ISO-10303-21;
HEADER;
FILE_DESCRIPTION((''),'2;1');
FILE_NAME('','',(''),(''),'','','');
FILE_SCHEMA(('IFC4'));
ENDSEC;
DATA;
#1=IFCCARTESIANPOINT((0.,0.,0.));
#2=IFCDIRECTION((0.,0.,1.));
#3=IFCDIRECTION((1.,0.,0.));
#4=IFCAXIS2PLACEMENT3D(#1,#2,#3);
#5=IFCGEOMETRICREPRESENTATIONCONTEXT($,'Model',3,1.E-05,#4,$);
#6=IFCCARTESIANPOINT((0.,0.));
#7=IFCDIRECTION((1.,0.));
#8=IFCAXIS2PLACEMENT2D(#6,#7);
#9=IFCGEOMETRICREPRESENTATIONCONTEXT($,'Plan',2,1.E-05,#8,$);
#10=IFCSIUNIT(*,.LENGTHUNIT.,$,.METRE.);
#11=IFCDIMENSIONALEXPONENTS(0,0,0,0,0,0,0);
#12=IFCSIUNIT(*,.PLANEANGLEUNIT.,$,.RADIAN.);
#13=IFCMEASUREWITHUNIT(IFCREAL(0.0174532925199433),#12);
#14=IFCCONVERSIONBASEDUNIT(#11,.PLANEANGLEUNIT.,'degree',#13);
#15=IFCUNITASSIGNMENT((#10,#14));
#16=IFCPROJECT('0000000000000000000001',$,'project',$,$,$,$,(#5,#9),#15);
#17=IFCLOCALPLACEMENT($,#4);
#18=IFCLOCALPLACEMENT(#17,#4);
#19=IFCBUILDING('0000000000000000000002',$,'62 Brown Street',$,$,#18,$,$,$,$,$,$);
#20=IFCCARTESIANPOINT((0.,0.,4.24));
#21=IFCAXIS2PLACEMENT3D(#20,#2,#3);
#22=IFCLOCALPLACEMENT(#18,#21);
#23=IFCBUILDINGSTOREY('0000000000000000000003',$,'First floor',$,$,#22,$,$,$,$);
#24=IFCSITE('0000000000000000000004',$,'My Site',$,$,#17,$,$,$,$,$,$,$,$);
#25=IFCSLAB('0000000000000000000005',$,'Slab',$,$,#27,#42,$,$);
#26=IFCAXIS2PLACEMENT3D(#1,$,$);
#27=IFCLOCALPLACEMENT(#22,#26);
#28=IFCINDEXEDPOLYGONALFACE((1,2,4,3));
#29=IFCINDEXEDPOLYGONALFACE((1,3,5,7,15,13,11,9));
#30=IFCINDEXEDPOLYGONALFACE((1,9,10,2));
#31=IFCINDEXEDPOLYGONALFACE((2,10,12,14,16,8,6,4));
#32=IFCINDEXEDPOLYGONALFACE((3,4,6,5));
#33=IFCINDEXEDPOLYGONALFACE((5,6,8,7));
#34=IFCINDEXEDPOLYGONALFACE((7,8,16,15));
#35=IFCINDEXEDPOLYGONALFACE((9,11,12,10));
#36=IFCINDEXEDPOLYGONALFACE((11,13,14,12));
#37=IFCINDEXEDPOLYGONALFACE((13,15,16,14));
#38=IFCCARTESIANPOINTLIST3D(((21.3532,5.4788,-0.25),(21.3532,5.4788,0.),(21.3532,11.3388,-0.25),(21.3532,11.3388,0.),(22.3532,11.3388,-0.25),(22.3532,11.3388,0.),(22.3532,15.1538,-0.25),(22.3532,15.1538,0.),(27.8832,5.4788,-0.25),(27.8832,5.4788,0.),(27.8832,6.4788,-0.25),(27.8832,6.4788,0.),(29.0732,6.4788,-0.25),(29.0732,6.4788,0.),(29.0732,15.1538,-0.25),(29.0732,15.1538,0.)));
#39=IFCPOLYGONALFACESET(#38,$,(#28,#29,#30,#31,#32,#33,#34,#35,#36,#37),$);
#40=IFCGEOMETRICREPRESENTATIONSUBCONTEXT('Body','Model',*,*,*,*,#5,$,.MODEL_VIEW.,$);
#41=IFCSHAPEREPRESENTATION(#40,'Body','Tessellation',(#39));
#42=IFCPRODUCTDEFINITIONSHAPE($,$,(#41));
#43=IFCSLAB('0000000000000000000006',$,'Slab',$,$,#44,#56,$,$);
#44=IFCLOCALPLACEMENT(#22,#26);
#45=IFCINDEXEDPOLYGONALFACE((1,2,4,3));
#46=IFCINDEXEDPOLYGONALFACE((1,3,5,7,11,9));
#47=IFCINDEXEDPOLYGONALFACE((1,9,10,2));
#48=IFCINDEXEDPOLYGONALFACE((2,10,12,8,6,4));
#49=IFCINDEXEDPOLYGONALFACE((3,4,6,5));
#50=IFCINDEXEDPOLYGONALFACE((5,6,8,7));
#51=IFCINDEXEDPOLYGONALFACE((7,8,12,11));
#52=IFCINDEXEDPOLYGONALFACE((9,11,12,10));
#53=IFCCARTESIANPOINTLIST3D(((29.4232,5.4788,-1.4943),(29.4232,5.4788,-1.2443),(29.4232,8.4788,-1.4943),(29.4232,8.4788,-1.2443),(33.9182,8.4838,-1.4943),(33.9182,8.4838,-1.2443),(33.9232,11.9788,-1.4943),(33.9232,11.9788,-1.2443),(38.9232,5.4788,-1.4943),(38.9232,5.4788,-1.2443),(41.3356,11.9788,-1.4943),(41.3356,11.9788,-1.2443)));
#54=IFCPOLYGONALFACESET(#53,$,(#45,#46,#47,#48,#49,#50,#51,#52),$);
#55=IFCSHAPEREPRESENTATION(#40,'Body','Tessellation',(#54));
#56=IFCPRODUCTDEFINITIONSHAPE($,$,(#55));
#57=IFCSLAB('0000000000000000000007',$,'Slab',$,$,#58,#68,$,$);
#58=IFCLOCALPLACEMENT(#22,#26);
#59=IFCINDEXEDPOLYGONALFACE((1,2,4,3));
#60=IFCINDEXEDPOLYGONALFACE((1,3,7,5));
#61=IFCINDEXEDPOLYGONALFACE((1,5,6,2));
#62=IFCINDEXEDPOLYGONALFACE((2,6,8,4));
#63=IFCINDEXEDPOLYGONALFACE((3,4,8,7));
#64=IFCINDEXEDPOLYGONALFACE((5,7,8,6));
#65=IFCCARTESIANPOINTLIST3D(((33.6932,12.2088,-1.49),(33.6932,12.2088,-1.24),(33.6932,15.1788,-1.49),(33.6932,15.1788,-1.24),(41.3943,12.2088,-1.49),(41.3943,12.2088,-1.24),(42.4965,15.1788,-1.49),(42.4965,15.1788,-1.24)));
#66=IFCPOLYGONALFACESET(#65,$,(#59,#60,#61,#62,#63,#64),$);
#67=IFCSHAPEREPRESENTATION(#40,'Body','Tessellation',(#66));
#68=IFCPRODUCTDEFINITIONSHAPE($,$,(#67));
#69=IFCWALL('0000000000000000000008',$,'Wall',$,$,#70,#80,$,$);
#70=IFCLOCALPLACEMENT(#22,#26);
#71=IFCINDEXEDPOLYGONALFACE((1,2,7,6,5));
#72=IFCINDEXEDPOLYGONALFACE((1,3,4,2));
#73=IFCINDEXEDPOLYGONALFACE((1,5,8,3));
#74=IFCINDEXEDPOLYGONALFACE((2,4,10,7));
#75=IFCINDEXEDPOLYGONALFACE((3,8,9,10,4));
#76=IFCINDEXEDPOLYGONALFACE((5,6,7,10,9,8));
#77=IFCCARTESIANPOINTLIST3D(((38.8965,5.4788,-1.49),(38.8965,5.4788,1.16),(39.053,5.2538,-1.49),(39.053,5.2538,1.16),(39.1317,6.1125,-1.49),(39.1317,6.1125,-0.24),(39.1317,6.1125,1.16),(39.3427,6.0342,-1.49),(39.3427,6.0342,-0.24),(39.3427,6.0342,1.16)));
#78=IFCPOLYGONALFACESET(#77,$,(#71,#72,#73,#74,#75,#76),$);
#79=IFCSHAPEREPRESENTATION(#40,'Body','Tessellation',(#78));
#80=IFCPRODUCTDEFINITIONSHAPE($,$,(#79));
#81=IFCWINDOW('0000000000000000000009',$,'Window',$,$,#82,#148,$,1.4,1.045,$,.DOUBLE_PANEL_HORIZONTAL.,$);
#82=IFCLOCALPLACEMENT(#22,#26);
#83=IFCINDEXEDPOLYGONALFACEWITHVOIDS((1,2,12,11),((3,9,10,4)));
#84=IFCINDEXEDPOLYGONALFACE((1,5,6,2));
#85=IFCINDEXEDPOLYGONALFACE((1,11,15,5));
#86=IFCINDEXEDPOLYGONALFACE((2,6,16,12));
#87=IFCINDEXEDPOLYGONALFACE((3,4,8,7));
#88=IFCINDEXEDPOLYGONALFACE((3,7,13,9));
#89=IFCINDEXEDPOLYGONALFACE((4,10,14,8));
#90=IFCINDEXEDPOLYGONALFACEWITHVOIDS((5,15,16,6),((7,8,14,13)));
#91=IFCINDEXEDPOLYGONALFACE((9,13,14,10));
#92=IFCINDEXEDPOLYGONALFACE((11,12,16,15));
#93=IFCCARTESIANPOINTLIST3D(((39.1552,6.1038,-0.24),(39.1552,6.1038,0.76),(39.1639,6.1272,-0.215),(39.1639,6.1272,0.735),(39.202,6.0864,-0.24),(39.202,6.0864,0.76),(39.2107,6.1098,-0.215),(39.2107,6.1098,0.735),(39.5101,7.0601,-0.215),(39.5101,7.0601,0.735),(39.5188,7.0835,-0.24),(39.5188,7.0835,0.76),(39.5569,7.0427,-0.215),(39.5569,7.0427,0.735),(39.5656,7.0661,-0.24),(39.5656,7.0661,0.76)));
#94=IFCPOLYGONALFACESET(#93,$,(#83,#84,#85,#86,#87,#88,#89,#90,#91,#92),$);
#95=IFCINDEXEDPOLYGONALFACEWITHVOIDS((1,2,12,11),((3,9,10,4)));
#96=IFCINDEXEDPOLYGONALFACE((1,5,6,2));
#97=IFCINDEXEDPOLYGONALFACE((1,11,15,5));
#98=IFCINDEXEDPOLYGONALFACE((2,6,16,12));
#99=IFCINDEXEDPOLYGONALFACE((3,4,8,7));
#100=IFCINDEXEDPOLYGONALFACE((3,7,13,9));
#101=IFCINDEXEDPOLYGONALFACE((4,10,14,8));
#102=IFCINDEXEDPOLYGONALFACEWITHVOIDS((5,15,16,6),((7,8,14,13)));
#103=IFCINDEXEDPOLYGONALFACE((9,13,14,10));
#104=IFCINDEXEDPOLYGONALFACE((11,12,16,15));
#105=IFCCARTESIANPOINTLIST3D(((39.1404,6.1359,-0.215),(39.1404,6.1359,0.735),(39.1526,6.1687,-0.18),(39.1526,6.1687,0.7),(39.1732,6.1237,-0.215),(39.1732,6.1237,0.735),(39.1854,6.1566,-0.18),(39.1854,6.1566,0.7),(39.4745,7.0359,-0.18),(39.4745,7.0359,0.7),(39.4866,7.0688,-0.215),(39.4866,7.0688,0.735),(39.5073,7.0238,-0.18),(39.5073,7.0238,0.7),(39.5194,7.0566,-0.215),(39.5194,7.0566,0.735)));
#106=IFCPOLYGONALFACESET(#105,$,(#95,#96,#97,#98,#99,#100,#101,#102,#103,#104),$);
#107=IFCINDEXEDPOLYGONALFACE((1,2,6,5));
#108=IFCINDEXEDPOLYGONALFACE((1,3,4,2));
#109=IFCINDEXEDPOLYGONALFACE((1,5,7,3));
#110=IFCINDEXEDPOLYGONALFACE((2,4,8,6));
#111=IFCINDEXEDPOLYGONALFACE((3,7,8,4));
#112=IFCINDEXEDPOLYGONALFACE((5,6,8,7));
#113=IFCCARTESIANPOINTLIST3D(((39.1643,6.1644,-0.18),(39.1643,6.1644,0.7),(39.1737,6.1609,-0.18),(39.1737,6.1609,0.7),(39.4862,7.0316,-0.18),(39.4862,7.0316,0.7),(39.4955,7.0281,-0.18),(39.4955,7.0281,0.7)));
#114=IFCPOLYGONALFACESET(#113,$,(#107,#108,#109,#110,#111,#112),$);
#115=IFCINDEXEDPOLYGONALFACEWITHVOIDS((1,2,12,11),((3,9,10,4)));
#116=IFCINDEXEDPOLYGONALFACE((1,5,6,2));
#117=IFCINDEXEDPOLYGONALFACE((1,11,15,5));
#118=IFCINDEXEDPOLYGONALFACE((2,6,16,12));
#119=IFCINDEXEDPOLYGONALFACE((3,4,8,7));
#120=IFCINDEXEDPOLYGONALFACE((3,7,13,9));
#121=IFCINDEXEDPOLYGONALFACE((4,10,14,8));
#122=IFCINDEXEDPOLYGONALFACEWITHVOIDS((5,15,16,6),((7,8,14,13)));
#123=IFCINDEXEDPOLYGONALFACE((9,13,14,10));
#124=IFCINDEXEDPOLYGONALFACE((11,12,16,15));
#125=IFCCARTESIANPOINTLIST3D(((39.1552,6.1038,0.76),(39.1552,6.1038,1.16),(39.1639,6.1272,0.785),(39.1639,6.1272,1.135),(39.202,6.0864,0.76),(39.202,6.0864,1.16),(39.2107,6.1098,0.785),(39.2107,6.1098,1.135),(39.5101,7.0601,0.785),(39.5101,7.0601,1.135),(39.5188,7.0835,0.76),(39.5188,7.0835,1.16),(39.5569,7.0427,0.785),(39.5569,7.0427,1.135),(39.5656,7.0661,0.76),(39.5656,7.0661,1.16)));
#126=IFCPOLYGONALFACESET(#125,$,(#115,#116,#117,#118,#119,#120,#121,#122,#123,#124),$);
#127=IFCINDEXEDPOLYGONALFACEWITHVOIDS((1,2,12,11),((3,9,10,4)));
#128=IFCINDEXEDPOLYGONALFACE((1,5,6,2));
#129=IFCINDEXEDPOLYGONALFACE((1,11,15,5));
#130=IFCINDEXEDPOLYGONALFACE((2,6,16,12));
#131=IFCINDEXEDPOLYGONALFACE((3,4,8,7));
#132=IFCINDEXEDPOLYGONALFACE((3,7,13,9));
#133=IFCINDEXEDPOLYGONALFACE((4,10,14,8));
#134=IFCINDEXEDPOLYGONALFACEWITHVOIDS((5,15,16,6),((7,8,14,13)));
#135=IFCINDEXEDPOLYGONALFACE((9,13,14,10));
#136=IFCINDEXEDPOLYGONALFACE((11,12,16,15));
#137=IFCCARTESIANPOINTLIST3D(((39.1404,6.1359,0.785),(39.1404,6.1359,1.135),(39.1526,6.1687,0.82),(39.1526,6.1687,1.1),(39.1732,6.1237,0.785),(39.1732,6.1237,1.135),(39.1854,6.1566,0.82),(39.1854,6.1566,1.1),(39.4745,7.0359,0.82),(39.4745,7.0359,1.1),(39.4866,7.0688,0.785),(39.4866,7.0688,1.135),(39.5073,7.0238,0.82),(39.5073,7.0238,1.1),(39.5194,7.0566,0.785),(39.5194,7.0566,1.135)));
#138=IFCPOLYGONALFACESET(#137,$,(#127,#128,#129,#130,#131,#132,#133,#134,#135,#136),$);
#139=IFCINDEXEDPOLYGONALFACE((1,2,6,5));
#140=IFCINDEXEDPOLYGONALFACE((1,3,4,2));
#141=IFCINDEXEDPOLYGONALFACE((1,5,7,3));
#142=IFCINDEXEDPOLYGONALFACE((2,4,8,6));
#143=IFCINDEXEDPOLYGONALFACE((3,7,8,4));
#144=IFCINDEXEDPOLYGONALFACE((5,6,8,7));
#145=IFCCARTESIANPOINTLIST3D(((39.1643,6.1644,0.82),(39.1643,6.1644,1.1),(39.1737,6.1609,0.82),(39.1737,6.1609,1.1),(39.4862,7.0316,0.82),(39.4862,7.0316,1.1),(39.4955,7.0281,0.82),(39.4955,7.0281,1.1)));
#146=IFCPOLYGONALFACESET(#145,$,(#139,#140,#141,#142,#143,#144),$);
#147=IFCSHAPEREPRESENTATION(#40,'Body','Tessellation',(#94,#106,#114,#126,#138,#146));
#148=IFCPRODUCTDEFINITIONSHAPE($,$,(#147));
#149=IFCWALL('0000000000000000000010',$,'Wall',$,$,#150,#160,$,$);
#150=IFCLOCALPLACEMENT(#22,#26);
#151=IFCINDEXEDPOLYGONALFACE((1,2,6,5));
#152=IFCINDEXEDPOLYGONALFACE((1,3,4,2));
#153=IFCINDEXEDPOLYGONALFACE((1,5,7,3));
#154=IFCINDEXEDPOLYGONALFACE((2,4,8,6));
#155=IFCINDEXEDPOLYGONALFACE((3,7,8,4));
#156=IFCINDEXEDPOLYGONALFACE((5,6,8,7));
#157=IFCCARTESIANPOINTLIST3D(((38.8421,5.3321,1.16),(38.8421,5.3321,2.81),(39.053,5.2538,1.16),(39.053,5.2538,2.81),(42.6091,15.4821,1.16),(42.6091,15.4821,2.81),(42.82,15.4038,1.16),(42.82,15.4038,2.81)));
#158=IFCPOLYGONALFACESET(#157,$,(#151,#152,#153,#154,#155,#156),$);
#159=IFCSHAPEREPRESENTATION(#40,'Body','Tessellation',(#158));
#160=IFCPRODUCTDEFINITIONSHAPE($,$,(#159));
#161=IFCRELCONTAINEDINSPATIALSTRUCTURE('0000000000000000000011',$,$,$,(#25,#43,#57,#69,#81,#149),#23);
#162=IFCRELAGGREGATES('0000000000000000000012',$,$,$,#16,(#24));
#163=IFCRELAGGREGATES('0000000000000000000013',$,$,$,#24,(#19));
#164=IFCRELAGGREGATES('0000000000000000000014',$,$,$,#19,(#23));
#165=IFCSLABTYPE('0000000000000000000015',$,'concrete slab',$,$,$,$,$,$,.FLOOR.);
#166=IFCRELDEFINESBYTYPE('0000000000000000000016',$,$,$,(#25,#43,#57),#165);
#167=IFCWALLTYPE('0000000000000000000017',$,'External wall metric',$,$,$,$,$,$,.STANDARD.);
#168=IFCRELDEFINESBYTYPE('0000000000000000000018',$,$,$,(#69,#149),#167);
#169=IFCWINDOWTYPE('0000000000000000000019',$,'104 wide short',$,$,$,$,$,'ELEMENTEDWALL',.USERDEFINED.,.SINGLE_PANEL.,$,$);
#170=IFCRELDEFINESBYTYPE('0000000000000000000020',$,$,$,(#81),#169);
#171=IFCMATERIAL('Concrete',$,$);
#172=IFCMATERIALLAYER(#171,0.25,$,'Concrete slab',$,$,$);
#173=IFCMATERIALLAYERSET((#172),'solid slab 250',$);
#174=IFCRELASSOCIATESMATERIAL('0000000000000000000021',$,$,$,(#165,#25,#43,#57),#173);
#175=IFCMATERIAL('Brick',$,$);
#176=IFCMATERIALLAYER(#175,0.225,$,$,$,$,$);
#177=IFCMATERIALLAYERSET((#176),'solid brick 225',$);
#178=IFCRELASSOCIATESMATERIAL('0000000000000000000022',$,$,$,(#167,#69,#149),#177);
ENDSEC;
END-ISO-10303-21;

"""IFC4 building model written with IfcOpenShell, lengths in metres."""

from ifc_helpers import new_model, entity, si_unit, converted_unit, frame, origin_with_axes, origin_2d_with_axis, place, context, subcontext, project, spatial, line, indexed_curve, outline, extrude, clip, halfspace, shape, source, transform, mapped, material, layer, layer_set, layer_usage, type_object, type_shapes, element, fill, save


model = new_model("IFC4")

# Units and contexts
model_context = context("Model", 3, precision=1e-05, world=origin_with_axes())
plan_context = context("Plan", 2, precision=1e-05, world=origin_2d_with_axis())
body_context_1 = subcontext(model_context, "Body", "Model", "MODEL_VIEW")
body_context_2 = subcontext(plan_context, "Body", "Plan", "PLAN_VIEW")
ifc_project = project(units=[si_unit("LENGTHUNIT", "METRE"), converted_unit("PLANEANGLEUNIT", "degree", entity("IfcReal", 0.0174532925199433), si_unit("PLANEANGLEUNIT", "RADIAN"), dimensions=[0, 0, 0, 0, 0, 0, 0])], contexts=[model_context, plan_context])

# Site, building, storey
site_placement = place(None, origin_with_axes())
site = spatial("IfcSite", under=ifc_project, at=site_placement, Name="My Site")
building_placement = place(site_placement, origin_with_axes())
building = spatial("IfcBuilding", under=site, at=building_placement, Name="62 Brown Street")
storey_placement = place(building_placement, frame((0.0, 0.0, 4.24), z_axis=(0.0, 0.0, 1.0), x_axis=(1.0, 0.0, 0.0)))
storey = spatial("IfcBuildingStorey", under=building, at=storey_placement, Name="First floor")

# Slabs
ifc_material_1 = material(Name="Concrete")
ifc_layer_1 = layer(ifc_material_1, 0.25, Name="Concrete slab")
ifc_layer_set_1 = layer_set([ifc_layer_1], Name="solid slab 250")
ifc_layer_usage_1 = layer_usage(ifc_layer_set_1, "AXIS3", "POSITIVE", 0.0)
slab_type = type_object("IfcSlabType", Name="concrete slab", PredefinedType="FLOOR", material=ifc_layer_set_1)
slab_1_placement = place(storey_placement, frame((21.3532, 5.4788, -0.25), z_axis=(0.0, 0.0, 1.0), x_axis=(1.0, 0.0, 0.0)))
element("IfcSlab", 1, at=slab_1_placement, inside=storey, type_object=slab_type, material=ifc_layer_usage_1, Name="Slab", context=body_context_1, shape_type="SweptSolid", body=[
    extrude(outline(indexed_curve([(0.0, 0.0), (0.0, 5.86), (1.0, 5.86), (1.0, 9.675), (7.72, 9.675), (7.72, 1.0), (6.53, 1.0), (6.53, 0.0)], segments=[line(2, 1), line(1, 8), line(8, 7), line(7, 6), line(6, 5), line(5, 4), line(4, 3), line(3, 2)], self_intersect=False)), None, (0.0, 0.0, 1.0), 0.25),
])
ifc_layer_usage_2 = layer_usage(ifc_layer_set_1, "AXIS3", "POSITIVE", 0.0)
slab_2_placement = place(storey_placement, frame((29.4232, 5.4788, -1.4943), z_axis=(0.0, 0.0, 1.0), x_axis=(1.0, 0.0, 0.0)))
element("IfcSlab", 2, at=slab_2_placement, inside=storey, type_object=slab_type, material=ifc_layer_usage_2, Name="Slab", context=body_context_1, shape_type="SweptSolid", body=[
    extrude(outline(indexed_curve([(0.0, 0.0), (9.5, 0.0), (11.9124, 6.5), (0.0, 3.0), (4.5, 6.5), (4.495, 3.005)], segments=[line(1, 2), line(2, 3), line(3, 5), line(5, 6), line(6, 4), line(4, 1)], self_intersect=False)), None, (0.0, 0.0, 1.0), 0.25),
])
ifc_layer_usage_3 = layer_usage(ifc_layer_set_1, "AXIS3", "POSITIVE", 0.0)
slab_3_placement = place(storey_placement, frame((33.6932, 12.2088, -1.49), z_axis=(0.0, 0.0, 1.0), x_axis=(1.0, 0.0, 0.0)))
element("IfcSlab", 3, at=slab_3_placement, inside=storey, type_object=slab_type, material=ifc_layer_usage_3, Name="Slab", context=body_context_1, shape_type="SweptSolid", body=[
    extrude(outline(indexed_curve([(8.8033, 2.97), (7.7011, 0.0), (0.0, 0.0), (0.0, 2.97)], segments=[line(4, 1), line(1, 2), line(2, 3), line(3, 4)], self_intersect=False)), None, (0.0, 0.0, 1.0), 0.25),
])

# Shared definitions
ifc_material_2 = material(Name="Brick")
ifc_layer_2 = layer(ifc_material_2, 0.225)
ifc_layer_set_2 = layer_set([ifc_layer_2], Name="solid brick 225")
wall_type_1 = type_object("IfcWallType", Name="External wall metric", PredefinedType="STANDARD", material=ifc_layer_set_2)

# Wall, opening, window
ifc_layer_usage_4 = layer_usage(ifc_layer_set_2, "AXIS2", "POSITIVE", 0.0)
wall_1_placement = place(storey_placement, frame((39.024, 5.1755, -1.49), z_axis=(0.0, 0.0, 1.0), x_axis=(0.347944, 0.937515, 0.0)))
wall_1 = element("IfcWall", 4, at=wall_1_placement, inside=storey, type_object=wall_type_1, material=ifc_layer_usage_4, Name="Wall", context=body_context_1, shape_type="Clipping", body=[
    clip(extrude(outline(indexed_curve([(0.0, 0.0), (0.0, 0.225), (0.9159, 0.225), (0.9159, 0.0), (0.0, 0.0)], self_intersect=False)), origin_with_axes(), (0.0, 0.0, 1.0), 2.65), halfspace(frame((0.0835, 0.0, -2.75), z_axis=(-0.596249, 0.414702, 0.0), x_axis=(0.156491, 0.225, 0.0)), False)),
])
shared_shape_1 = source(origin_with_axes(), body_context_1, "Body", "SweptSolid", [
    extrude(outline(indexed_curve([(0.0, 0.0), (1.045, 0.0), (1.045, 1.4), (0.0, 1.4)], segments=[line(1, 2, 3, 4, 1)])), frame((0.0, -0.1, 0.0), z_axis=(0.0, -1.0, 0.0), x_axis=(1.0, 0.0, 0.0)), (0.0, 0.0, -1.0), 0.425),
])
opening_placement = place(wall_1_placement, frame((0.9159, 0.0, 1.25), z_axis=(0.0, 0.0, 1.0), x_axis=(1.0, 0.0, 0.0)))
opening = element("IfcOpeningElement", 5, at=opening_placement, cuts=wall_1, PredefinedType="OPENING", context=body_context_1, shape_type="MappedRepresentation", body=[
    mapped(shared_shape_1, transform((0.0, 0.0, 0.0), x_axis=(1.0, 0.0, 0.0), y_axis=(0.0, 1.0, 0.0), z_axis=(0.0, 0.0, 1.0), scale=1.0)),
])
window_type = type_object("IfcWindowType", Name="104 wide short", ElementType="ELEMENTEDWALL", PartitioningType="SINGLE_PANEL", PredefinedType="USERDEFINED")
shared_shape_2 = source(origin_with_axes(), body_context_1, "Body", "SweptSolid", [
    extrude(outline(indexed_curve([(0.0, 0.0), (1.045, 0.0), (1.045, 1.0), (0.0, 1.0)], segments=[line(1, 2, 3, 4, 1)]), holes=[indexed_curve([(0.025, 0.025), (1.02, 0.025), (1.02, 0.975), (0.025, 0.975)], segments=[line(1, 2, 3, 4, 1)])]), frame((0.0, 0.15, 0.0), z_axis=(0.0, -1.0, 0.0), x_axis=(1.0, 0.0, 0.0)), (0.0, 0.0, -1.0), 0.05),
    extrude(outline(indexed_curve([(0.0, 0.0), (0.995, 0.0), (0.995, 0.95), (0.0, 0.95)], segments=[line(1, 2, 3, 4, 1)]), holes=[indexed_curve([(0.035, 0.035), (0.96, 0.035), (0.96, 0.915), (0.035, 0.915)], segments=[line(1, 2, 3, 4, 1)])]), frame((0.025, 0.19, 0.025), z_axis=(0.0, -1.0, 0.0), x_axis=(1.0, 0.0, 0.0)), (0.0, 0.0, -1.0), 0.035),
    extrude(outline(indexed_curve([(0.035, 0.035), (0.96, 0.035), (0.96, 0.915), (0.035, 0.915)], segments=[line(1, 2, 3, 4, 1)])), frame((0.025, 0.2025, 0.025), z_axis=(0.0, -1.0, 0.0), x_axis=(1.0, 0.0, 0.0)), (0.0, 0.0, -1.0), 0.01),
    extrude(outline(indexed_curve([(0.0, 0.0), (1.045, 0.0), (1.045, 0.4), (0.0, 0.4)], segments=[line(1, 2, 3, 4, 1)]), holes=[indexed_curve([(0.025, 0.025), (1.02, 0.025), (1.02, 0.375), (0.025, 0.375)], segments=[line(1, 2, 3, 4, 1)])]), frame((0.0, 0.15, 1.0), z_axis=(0.0, -1.0, 0.0), x_axis=(1.0, 0.0, 0.0)), (0.0, 0.0, -1.0), 0.05),
    extrude(outline(indexed_curve([(0.0, 0.0), (0.995, 0.0), (0.995, 0.35), (0.0, 0.35)], segments=[line(1, 2, 3, 4, 1)]), holes=[indexed_curve([(0.035, 0.035), (0.96, 0.035), (0.96, 0.315), (0.035, 0.315)], segments=[line(1, 2, 3, 4, 1)])]), frame((0.025, 0.19, 1.025), z_axis=(0.0, -1.0, 0.0), x_axis=(1.0, 0.0, 0.0)), (0.0, 0.0, -1.0), 0.035),
    extrude(outline(indexed_curve([(0.035, 0.035), (0.96, 0.035), (0.96, 0.315), (0.035, 0.315)], segments=[line(1, 2, 3, 4, 1)])), frame((0.025, 0.2025, 1.025), z_axis=(0.0, -1.0, 0.0), x_axis=(1.0, 0.0, 0.0)), (0.0, 0.0, -1.0), 0.01),
])
shared_shape_3 = source(origin_with_axes(), body_context_2, "Body", "Curve2D", [
    entity("IfcIndexedPolyCurve", entity("IfcCartesianPointList2D", [[0.025, 0.15], [1.02, 0.15]])),
    entity("IfcIndexedPolyCurve", entity("IfcCartesianPointList2D", [[0.0, 0.2], [0.025, 0.2], [0.025, 0.15], [0.0, 0.15]]), [entity("IfcLineIndex", [1, 2, 3, 4, 1])]),
    entity("IfcIndexedPolyCurve", entity("IfcCartesianPointList2D", [[1.045, 0.2], [1.02, 0.2], [1.02, 0.15], [1.045, 0.15]]), [entity("IfcLineIndex", [1, 2, 3, 4, 1])]),
    entity("IfcIndexedPolyCurve", entity("IfcCartesianPointList2D", [[0.025, 0.19], [0.06, 0.19], [0.06, 0.225], [0.025, 0.225]]), [entity("IfcLineIndex", [1, 2, 3, 4, 1])]),
    entity("IfcIndexedPolyCurve", entity("IfcCartesianPointList2D", [[1.02, 0.19], [0.985, 0.19], [0.985, 0.225], [1.02, 0.225]]), [entity("IfcLineIndex", [1, 2, 3, 4, 1])]),
    entity("IfcIndexedPolyCurve", entity("IfcCartesianPointList2D", [[0.06, 0.19], [0.985, 0.19]])),
    entity("IfcIndexedPolyCurve", entity("IfcCartesianPointList2D", [[0.06, 0.225], [0.985, 0.225]])),
    entity("IfcIndexedPolyCurve", entity("IfcCartesianPointList2D", [[0.06, 0.2075], [0.985, 0.2075]])),
])
type_shapes(window_type, [shared_shape_2, shared_shape_3])
window_1_placement = place(opening_placement, frame((0.0, 0.0, 0.0), z_axis=(0.0, 0.0, 1.0), x_axis=(1.0, 0.0, 0.0)))
window_1 = element("IfcWindow", 6, at=window_1_placement, inside=storey, type_object=window_type, Name="Window", OverallHeight=1.4, OverallWidth=1.045, PartitioningType="DOUBLE_PANEL_HORIZONTAL", shapes=[
    shape(body_context_1, "Body", "MappedRepresentation", [mapped(shared_shape_2, transform((0.0, 0.0, 0.0), x_axis=(1.0, 0.0, 0.0), y_axis=(0.0, 1.0, 0.0), z_axis=(0.0, 0.0, 1.0), scale=1.0))]),
    shape(body_context_2, "Body", "MappedRepresentation", [mapped(shared_shape_3, transform((0.0, 0.0, 0.0), x_axis=(1.0, 0.0, 0.0), y_axis=(0.0, 1.0, 0.0), z_axis=(0.0, 0.0, 1.0), scale=1.0))]),
])
fill(opening, window_1)

# Wall
ifc_layer_usage_5 = layer_usage(ifc_layer_set_2, "AXIS2", "POSITIVE", 0.0)
wall_2_placement = place(storey_placement, frame((39.053, 5.2538, 1.16), z_axis=(0.0, 0.0, 1.0), x_axis=(0.347944, 0.937515, 0.0)))
element("IfcWall", 7, at=wall_2_placement, inside=storey, type_object=wall_type_1, material=ifc_layer_usage_5, Name="Wall", context=body_context_1, shape_type="SweptSolid", body=[
    extrude(outline(indexed_curve([(0.0, 0.0), (0.0, 0.225), (10.8265, 0.225), (10.8265, 0.0), (0.0, 0.0)], self_intersect=False)), origin_with_axes(), (0.0, 0.0, 1.0), 1.65),
])

save(model, "model.ifc")
